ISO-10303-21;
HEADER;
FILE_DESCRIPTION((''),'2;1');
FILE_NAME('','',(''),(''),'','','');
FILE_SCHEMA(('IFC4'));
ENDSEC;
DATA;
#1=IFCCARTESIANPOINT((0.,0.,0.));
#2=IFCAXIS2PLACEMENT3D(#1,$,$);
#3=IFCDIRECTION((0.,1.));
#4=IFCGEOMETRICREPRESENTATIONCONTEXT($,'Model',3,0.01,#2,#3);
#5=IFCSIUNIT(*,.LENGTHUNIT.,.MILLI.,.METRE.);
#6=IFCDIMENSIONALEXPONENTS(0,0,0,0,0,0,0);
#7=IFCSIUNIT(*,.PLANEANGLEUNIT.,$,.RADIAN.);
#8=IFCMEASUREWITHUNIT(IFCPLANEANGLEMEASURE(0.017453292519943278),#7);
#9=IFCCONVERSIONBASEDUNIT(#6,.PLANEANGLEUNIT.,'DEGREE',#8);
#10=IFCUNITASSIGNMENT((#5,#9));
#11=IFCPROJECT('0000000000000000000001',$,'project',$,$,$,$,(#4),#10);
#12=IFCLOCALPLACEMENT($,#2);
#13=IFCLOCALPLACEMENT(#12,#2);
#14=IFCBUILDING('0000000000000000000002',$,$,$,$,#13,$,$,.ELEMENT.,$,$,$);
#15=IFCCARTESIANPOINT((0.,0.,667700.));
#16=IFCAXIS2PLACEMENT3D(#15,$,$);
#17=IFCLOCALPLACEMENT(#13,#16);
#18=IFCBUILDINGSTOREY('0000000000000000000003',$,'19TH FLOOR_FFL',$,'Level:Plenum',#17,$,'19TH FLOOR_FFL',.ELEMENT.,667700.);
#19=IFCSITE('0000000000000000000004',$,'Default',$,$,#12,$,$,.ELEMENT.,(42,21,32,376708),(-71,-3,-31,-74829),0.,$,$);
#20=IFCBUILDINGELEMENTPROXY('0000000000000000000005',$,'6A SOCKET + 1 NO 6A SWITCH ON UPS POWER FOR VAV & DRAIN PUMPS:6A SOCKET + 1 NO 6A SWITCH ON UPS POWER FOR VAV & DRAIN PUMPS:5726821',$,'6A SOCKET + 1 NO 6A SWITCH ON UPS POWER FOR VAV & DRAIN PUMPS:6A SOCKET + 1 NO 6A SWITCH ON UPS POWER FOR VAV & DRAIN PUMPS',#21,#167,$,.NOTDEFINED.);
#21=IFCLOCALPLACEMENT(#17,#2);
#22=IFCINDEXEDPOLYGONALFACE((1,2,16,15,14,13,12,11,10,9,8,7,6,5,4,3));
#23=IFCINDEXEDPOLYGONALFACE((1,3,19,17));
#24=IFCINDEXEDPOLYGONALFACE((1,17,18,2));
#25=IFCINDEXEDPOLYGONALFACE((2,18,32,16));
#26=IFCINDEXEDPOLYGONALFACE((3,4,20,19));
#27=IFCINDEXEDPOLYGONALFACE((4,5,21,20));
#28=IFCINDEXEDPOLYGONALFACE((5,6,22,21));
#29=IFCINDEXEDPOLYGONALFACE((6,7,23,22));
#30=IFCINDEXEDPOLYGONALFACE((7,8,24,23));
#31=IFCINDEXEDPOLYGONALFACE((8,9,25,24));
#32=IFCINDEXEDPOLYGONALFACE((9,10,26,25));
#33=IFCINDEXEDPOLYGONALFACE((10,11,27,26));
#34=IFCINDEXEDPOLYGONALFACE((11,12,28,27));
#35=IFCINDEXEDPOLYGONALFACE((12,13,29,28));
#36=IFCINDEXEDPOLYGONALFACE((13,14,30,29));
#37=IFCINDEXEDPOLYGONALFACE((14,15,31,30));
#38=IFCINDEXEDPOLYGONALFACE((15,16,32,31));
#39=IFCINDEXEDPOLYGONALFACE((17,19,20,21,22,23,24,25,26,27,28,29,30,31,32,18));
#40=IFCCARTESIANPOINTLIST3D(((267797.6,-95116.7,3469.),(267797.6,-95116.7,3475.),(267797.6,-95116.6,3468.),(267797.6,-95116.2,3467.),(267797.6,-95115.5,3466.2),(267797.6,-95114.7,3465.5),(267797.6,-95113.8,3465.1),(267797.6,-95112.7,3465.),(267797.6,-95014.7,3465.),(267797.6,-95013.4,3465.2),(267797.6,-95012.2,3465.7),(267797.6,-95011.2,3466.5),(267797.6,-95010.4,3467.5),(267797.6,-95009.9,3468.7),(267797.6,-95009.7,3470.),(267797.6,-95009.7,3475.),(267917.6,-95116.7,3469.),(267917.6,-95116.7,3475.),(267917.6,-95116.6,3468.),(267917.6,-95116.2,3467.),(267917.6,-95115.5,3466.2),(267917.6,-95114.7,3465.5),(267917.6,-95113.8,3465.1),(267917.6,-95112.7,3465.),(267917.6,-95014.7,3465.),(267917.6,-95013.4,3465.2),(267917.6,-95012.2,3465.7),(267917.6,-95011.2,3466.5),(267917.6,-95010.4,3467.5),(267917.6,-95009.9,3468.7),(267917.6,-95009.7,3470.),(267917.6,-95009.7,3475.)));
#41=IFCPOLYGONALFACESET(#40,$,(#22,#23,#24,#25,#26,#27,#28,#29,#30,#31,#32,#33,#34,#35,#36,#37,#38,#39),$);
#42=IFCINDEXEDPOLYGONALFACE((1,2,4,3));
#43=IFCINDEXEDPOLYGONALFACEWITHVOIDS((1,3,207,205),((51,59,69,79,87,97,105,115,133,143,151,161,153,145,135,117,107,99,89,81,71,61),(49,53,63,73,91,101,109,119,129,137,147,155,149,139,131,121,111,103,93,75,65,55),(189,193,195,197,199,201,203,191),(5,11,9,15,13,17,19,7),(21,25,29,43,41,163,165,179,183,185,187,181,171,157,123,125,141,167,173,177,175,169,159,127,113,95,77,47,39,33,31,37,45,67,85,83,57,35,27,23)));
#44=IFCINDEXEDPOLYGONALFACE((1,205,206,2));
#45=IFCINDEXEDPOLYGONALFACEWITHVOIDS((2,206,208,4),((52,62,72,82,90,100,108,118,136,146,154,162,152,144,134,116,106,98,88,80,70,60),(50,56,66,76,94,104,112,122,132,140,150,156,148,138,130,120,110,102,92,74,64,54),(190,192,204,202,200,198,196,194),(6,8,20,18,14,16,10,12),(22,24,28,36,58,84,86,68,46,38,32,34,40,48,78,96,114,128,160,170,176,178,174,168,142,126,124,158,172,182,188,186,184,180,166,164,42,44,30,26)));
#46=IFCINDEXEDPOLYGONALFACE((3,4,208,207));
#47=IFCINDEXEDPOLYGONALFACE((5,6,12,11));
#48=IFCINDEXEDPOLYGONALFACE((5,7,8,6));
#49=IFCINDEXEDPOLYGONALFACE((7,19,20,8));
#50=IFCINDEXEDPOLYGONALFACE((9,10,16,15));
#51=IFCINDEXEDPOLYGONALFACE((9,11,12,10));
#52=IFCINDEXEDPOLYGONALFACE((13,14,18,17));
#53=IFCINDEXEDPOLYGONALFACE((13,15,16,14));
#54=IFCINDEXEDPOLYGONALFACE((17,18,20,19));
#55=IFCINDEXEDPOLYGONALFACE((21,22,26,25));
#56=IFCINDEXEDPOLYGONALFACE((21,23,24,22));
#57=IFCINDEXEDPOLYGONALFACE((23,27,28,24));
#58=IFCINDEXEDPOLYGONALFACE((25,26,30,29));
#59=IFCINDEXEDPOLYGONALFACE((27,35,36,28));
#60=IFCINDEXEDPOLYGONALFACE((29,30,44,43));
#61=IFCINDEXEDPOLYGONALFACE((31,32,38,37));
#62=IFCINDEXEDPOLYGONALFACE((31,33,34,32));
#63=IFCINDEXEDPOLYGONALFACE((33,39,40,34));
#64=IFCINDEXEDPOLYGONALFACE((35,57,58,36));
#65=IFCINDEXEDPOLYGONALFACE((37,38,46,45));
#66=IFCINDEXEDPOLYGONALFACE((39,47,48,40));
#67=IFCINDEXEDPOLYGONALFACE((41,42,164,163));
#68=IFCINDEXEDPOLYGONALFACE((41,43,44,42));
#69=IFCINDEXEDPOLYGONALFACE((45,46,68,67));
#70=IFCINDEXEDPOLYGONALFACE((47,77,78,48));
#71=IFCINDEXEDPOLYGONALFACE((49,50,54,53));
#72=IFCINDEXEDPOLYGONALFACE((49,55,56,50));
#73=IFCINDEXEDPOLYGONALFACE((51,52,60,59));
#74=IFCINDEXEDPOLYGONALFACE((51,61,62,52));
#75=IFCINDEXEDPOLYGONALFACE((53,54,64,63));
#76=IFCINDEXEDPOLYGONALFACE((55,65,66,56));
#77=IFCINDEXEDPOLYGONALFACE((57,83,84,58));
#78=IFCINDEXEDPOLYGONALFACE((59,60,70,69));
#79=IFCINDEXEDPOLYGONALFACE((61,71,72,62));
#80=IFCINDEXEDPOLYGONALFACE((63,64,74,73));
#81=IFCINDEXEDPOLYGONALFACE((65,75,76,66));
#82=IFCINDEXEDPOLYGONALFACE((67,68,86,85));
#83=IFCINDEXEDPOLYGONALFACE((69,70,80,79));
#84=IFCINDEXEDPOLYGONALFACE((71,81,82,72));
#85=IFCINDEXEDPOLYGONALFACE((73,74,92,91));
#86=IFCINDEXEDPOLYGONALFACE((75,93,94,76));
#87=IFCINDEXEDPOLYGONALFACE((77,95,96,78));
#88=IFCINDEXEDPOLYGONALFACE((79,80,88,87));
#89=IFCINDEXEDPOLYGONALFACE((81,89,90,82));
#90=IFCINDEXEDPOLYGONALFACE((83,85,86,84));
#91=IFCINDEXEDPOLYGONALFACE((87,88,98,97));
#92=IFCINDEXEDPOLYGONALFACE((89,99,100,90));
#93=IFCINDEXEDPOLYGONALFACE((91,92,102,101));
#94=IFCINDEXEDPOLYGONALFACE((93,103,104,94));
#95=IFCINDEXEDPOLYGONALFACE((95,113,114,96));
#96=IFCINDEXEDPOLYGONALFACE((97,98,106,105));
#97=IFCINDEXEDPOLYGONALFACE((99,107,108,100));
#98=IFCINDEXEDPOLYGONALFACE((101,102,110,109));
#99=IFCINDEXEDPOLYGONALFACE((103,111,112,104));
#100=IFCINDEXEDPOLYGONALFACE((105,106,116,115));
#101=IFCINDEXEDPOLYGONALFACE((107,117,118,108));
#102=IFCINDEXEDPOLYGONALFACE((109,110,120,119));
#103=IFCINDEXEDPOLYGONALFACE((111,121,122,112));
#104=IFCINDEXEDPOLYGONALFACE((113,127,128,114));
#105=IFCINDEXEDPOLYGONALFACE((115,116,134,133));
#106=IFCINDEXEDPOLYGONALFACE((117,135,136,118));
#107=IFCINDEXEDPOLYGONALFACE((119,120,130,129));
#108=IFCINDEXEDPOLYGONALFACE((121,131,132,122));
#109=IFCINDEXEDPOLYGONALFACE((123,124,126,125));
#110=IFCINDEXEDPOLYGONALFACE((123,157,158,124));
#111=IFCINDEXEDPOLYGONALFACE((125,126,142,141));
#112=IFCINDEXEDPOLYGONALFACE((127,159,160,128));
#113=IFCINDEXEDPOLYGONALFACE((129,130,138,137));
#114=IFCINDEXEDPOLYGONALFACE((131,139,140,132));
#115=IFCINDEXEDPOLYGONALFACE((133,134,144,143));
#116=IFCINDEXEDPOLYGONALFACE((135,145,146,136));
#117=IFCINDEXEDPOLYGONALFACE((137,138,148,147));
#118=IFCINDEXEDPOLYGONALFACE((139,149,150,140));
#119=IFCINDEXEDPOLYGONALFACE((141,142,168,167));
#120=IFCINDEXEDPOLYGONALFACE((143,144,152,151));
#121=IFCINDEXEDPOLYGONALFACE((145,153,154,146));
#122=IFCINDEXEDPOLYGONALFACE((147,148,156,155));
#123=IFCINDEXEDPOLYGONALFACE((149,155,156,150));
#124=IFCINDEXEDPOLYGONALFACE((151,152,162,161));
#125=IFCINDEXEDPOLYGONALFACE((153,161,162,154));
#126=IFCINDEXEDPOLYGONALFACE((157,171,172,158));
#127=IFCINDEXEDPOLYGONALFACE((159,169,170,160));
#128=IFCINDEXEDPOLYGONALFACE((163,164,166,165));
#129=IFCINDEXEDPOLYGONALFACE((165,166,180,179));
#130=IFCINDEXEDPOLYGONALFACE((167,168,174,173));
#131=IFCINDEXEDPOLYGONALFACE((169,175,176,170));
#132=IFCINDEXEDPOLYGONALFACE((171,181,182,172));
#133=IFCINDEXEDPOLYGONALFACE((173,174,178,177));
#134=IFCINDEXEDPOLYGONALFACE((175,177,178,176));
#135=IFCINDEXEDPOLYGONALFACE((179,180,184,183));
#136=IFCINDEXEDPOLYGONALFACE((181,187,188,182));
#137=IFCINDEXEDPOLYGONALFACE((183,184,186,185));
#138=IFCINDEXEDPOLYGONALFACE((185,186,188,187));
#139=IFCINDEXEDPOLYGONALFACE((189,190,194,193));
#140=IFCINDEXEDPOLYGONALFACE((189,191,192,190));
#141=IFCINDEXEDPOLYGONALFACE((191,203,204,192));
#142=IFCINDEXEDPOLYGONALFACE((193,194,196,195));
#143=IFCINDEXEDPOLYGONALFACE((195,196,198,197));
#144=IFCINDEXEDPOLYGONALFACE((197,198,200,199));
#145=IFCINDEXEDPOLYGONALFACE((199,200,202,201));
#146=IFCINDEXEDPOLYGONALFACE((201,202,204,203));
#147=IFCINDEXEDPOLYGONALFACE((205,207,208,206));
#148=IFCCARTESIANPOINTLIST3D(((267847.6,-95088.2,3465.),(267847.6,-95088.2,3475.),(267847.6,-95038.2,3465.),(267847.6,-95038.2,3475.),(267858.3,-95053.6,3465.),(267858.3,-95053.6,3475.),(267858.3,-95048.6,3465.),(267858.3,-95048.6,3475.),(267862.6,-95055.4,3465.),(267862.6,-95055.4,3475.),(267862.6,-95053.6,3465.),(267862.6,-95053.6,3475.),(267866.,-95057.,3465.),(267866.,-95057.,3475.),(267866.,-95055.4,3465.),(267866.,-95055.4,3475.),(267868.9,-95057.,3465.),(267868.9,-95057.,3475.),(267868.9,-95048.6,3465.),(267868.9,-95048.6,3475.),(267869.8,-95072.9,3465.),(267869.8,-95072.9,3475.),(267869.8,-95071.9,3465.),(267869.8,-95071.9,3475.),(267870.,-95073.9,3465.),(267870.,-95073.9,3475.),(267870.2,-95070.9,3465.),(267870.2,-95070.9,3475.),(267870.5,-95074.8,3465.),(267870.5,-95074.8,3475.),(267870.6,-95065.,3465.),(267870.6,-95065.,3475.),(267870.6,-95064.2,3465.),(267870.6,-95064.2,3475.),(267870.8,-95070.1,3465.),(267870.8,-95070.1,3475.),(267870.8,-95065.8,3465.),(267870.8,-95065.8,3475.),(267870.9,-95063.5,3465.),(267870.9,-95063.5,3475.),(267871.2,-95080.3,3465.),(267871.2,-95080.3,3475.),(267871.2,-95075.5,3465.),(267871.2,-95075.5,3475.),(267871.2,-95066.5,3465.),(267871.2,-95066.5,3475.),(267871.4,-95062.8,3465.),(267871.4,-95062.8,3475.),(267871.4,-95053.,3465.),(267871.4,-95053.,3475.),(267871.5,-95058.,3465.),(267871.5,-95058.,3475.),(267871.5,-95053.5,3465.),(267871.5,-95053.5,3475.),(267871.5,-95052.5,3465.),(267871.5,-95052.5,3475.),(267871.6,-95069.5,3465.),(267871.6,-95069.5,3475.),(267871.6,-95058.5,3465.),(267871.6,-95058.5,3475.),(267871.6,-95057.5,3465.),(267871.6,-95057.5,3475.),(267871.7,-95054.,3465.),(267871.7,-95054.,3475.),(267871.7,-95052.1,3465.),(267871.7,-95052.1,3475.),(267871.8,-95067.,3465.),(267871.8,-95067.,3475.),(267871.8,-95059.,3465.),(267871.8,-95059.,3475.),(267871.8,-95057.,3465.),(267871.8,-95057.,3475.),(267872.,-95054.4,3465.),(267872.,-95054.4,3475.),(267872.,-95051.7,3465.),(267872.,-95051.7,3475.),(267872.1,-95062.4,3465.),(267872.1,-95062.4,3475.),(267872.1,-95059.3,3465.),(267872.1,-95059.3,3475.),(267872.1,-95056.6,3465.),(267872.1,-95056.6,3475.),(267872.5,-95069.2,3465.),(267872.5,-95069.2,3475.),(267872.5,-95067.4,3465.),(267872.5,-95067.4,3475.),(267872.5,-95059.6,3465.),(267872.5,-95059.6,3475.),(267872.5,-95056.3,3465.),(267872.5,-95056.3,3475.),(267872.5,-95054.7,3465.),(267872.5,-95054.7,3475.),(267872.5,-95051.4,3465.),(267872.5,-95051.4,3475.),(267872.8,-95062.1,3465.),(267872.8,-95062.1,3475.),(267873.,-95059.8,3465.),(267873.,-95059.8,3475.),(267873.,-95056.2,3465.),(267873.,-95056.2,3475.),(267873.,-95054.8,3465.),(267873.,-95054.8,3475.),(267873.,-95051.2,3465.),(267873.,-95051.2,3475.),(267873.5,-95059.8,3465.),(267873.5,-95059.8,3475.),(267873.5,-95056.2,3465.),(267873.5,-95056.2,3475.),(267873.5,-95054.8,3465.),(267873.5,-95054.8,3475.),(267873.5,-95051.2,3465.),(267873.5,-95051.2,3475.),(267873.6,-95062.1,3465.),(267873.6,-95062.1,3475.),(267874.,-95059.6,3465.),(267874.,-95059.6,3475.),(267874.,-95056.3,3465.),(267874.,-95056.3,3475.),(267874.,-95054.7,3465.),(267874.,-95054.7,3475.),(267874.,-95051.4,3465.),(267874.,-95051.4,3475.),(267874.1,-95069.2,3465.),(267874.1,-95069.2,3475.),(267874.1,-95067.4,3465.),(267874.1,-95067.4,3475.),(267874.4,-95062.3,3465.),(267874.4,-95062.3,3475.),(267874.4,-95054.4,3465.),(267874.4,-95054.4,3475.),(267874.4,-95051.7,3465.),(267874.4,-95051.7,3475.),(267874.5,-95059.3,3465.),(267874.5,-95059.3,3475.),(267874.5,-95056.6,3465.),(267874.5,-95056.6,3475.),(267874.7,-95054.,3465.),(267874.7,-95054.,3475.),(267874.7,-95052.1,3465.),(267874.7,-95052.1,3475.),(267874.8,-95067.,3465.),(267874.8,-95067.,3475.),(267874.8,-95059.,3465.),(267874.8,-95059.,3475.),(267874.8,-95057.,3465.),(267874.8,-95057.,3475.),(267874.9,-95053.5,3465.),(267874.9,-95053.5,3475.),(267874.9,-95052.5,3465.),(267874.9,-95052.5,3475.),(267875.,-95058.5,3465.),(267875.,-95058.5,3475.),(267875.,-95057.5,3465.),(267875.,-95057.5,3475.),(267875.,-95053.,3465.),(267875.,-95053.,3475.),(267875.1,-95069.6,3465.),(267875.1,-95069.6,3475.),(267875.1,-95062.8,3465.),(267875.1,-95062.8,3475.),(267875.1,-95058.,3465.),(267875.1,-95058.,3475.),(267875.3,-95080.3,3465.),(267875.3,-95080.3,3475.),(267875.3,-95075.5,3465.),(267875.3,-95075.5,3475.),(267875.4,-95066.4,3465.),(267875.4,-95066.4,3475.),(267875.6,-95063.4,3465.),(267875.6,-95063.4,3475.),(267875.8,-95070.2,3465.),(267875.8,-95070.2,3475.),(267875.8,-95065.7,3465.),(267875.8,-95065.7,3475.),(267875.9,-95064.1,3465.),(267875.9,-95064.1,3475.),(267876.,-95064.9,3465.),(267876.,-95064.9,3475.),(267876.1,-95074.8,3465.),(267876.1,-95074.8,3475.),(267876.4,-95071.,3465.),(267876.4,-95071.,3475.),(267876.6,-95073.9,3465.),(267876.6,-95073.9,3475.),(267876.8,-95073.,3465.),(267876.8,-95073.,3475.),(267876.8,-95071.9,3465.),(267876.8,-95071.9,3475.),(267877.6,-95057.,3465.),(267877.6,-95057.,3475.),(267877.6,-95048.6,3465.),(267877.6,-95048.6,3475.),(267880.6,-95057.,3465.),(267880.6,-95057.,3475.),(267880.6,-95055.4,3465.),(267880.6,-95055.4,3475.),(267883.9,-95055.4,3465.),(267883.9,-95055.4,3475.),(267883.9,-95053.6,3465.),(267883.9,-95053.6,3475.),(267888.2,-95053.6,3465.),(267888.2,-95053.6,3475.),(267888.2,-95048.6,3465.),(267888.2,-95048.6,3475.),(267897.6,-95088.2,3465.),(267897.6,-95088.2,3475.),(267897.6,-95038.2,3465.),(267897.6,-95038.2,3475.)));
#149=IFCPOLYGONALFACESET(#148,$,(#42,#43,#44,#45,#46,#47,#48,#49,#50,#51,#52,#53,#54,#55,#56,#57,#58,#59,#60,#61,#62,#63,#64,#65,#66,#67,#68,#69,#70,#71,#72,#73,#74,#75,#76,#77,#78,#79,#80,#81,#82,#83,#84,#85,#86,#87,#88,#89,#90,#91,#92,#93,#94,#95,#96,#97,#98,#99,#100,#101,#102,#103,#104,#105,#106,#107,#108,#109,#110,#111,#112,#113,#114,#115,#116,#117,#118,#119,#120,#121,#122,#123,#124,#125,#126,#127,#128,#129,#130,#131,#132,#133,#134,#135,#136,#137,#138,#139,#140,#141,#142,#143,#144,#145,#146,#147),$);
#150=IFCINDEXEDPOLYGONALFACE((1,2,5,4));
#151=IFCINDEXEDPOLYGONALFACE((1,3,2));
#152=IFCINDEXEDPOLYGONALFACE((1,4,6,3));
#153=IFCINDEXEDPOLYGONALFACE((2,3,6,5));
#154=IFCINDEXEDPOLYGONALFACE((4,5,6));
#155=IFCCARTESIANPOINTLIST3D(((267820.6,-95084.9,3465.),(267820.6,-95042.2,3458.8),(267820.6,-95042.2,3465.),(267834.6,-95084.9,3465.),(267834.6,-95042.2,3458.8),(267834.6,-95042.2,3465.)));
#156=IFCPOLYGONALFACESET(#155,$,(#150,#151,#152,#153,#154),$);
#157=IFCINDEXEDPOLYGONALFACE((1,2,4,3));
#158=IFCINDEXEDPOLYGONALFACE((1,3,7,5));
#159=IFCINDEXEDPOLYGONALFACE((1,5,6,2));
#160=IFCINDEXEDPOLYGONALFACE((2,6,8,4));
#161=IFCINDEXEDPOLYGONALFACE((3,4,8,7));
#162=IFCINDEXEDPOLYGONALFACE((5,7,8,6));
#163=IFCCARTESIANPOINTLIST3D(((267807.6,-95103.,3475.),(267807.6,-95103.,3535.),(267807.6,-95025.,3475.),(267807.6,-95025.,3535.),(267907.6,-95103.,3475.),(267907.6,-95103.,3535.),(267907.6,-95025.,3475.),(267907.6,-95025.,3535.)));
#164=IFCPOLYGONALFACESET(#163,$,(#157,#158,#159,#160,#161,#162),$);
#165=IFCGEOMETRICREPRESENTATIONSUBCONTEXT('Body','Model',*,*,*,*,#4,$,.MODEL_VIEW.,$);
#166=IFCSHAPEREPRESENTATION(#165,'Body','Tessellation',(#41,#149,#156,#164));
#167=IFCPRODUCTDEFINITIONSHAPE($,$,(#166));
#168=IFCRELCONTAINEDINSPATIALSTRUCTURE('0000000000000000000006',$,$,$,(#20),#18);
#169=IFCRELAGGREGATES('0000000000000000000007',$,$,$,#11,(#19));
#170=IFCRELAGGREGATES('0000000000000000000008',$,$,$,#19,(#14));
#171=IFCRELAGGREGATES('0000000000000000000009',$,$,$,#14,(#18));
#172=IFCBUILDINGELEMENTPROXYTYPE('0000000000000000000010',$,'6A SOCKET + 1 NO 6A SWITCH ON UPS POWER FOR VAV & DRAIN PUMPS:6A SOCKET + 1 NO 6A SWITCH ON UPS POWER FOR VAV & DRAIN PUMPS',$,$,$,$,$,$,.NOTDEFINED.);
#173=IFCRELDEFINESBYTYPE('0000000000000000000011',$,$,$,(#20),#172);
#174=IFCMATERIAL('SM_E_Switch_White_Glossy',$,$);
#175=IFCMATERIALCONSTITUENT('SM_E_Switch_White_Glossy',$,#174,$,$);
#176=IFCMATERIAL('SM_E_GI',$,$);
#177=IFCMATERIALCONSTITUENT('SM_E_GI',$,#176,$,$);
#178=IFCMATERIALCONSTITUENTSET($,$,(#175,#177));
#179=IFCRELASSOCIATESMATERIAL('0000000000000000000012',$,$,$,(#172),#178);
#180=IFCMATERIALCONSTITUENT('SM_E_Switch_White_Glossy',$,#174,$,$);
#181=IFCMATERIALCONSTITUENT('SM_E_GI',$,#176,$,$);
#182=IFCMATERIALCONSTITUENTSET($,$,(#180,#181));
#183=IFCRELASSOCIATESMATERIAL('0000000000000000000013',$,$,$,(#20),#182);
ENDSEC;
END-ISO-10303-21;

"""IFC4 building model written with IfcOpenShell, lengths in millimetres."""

from ifc_helpers import new_model, entity, si_unit, converted_unit, direction, frame, origin, place, context, subcontext, project, spatial, line, arc, indexed_curve, outline, extrude, source, transform, mapped, material, constituent, constituent_set, type_object, type_shapes, element, save


model = new_model("IFC4")

# Units and contexts
model_context = context("Model", 3, precision=0.01, world=origin(), true_north=direction((0.0, 1.0)))
body_context = subcontext(model_context, "Body", "Model", "MODEL_VIEW")
ifc_project = project(units=[si_unit("LENGTHUNIT", "METRE", prefix="MILLI"), converted_unit("PLANEANGLEUNIT", "DEGREE", entity("IfcPlaneAngleMeasure", 0.017453292519943278), si_unit("PLANEANGLEUNIT", "RADIAN"), dimensions=[0, 0, 0, 0, 0, 0, 0])], contexts=[model_context])

# Site, building, storey
site_placement = place(None, origin())
site = spatial("IfcSite", under=ifc_project, at=site_placement, Name="Default", CompositionType="ELEMENT", RefLatitude=(42, 21, 32, 376708), RefLongitude=(-71, -3, -31, -74829), RefElevation=0.0)
building_placement = place(site_placement, origin())
building = spatial("IfcBuilding", under=site, at=building_placement, CompositionType="ELEMENT")
storey_placement = place(building_placement, frame((0.0, 0.0, 667700.0)))
storey = spatial("IfcBuildingStorey", under=building, at=storey_placement, Name="19TH FLOOR_FFL", ObjectType="Level:Plenum", LongName="19TH FLOOR_FFL", CompositionType="ELEMENT", Elevation=667700.0)

# Shared definitions
ifc_material_1 = material(Name="SM_E_Switch_White_Glossy")
ifc_material_2 = material(Name="SM_E_GI")

# Building element proxy
ifc_constituent_1 = constituent(ifc_material_1, Name="SM_E_Switch_White_Glossy")
ifc_constituent_2 = constituent(ifc_material_2, Name="SM_E_GI")
ifc_constituent_set_1 = constituent_set(constituents=[ifc_constituent_1, ifc_constituent_2])
ifc_constituent_3 = constituent(ifc_material_1, Name="SM_E_Switch_White_Glossy")
ifc_constituent_4 = constituent(ifc_material_2, Name="SM_E_GI")
ifc_constituent_set_2 = constituent_set(constituents=[ifc_constituent_3, ifc_constituent_4])
building_element_proxy_type_1 = type_object("IfcBuildingElementProxyType", Name="6A SOCKET + 1 NO 6A SWITCH ON UPS POWER FOR VAV & DRAIN PUMPS:6A SOCKET + 1 NO 6A SWITCH ON UPS POWER FOR VAV & DRAIN PUMPS", PredefinedType="NOTDEFINED", material=ifc_constituent_set_2)
shared_shape_1 = source(origin(), body_context, "Body", "SweptSolid", [
    extrude(outline(indexed_curve([(-5.2, -53.7), (-0.2, -53.7), (3.4, -52.2), (4.8, -48.7), (4.8, 49.3), (3.7, 52.2), (0.8, 53.3), (-5.2, 53.3)], segments=[line(1, 2), arc(2, 3, 4), line(4, 5), arc(5, 6, 7), line(7, 8, 1)], self_intersect=False)), frame((-60.0, 53.3, 5.2), z_axis=(1.0, 0.0, 0.0), x_axis=(0.0, 0.0, 1.0)), (0.0, 0.0, 1.0), 120.0),
    extrude(outline(indexed_curve([(-25.0, -25.0), (25.0, -25.0), (25.0, 25.0), (-25.0, 25.0), (-25.0, -25.0)], self_intersect=False), holes=[indexed_curve([(-5.9, -0.1), (-8.7, -2.8), (-12.3, -1.4), (-17.1, -1.4), (-17.1, 2.7), (-12.3, 2.7), (-8.7, 4.1), (-6.0, 1.5), (-4.1, 1.5), (1.1, 0.6), (-4.2, -0.1)], segments=[arc(1, 2, 3), line(3, 4, 5, 6), arc(6, 7, 8), line(8, 9), arc(9, 10, 11), line(11, 1)], self_intersect=False), indexed_curve([(5.2, 2.4), (7.0, 0.6), (5.2, -1.2), (3.4, 0.6)], segments=[arc(1, 2, 3), arc(3, 4, 1)], self_intersect=False), indexed_curve([(10.2, 2.4), (12.0, 0.6), (10.2, -1.2), (8.4, 0.6)], segments=[arc(1, 2, 3), arc(3, 4, 1)], self_intersect=False), indexed_curve([(14.7, 15.6), (14.7, 5.0), (6.3, 5.0), (6.3, 7.9), (7.8, 7.9), (7.8, 11.3), (9.7, 11.3), (9.7, 15.6), (14.7, 15.6)], self_intersect=False), indexed_curve([(14.7, -14.3), (9.7, -14.3), (9.7, -10.0), (7.8, -10.0), (7.8, -6.6), (6.3, -6.6), (6.3, -3.7), (14.7, -3.7), (14.7, -14.3)], self_intersect=False)]), frame((-15.0, 53.5, 0.0), z_axis=(0.0, 0.0, 1.0), x_axis=(0.0, 1.0, 0.0)), (0.0, 0.0, 1.0), 10.0),
    extrude(outline(indexed_curve([(-14.7, -2.0), (28.5, -2.0), (-13.8, 4.1), (-14.7, -2.0)], self_intersect=False)), frame((23.0, 60.3, 12.1), z_axis=(1.0, 0.0, 0.0), x_axis=(0.0, -0.989716, -0.143046)), (0.0, 0.0, 1.0), 14.0),
    extrude(outline(indexed_curve([(-39.0, -50.0), (39.0, -50.0), (39.0, 50.0), (-39.0, 50.0), (-39.0, -50.0)], self_intersect=False)), frame((0.0, 52.8, -60.0), z_axis=(0.0, 0.0, 1.0), x_axis=(0.0, 1.0, 0.0)), (0.0, 0.0, 1.0), 60.0),
])
type_shapes(building_element_proxy_type_1, [shared_shape_1])
proxy_1_placement = place(storey_placement, frame((267857.6, -95116.7, 3475.0), z_axis=(0.0, 0.0, -1.0), x_axis=(-1.0, 0.0, 0.0)))
element("IfcBuildingElementProxy", 1, at=proxy_1_placement, inside=storey, type_object=building_element_proxy_type_1, material=ifc_constituent_set_1, Name="6A SOCKET + 1 NO 6A SWITCH ON UPS POWER FOR VAV & DRAIN PUMPS:6A SOCKET + 1 NO 6A SWITCH ON UPS POWER FOR VAV & DRAIN PUMPS:5726821", ObjectType="6A SOCKET + 1 NO 6A SWITCH ON UPS POWER FOR VAV & DRAIN PUMPS:6A SOCKET + 1 NO 6A SWITCH ON UPS POWER FOR VAV & DRAIN PUMPS", PredefinedType="NOTDEFINED", context=body_context, shape_type="MappedRepresentation", body=[
    mapped(shared_shape_1, transform((0.0, 0.0, 0.0), scale=1.0)),
])

save(model, "model.ifc")
